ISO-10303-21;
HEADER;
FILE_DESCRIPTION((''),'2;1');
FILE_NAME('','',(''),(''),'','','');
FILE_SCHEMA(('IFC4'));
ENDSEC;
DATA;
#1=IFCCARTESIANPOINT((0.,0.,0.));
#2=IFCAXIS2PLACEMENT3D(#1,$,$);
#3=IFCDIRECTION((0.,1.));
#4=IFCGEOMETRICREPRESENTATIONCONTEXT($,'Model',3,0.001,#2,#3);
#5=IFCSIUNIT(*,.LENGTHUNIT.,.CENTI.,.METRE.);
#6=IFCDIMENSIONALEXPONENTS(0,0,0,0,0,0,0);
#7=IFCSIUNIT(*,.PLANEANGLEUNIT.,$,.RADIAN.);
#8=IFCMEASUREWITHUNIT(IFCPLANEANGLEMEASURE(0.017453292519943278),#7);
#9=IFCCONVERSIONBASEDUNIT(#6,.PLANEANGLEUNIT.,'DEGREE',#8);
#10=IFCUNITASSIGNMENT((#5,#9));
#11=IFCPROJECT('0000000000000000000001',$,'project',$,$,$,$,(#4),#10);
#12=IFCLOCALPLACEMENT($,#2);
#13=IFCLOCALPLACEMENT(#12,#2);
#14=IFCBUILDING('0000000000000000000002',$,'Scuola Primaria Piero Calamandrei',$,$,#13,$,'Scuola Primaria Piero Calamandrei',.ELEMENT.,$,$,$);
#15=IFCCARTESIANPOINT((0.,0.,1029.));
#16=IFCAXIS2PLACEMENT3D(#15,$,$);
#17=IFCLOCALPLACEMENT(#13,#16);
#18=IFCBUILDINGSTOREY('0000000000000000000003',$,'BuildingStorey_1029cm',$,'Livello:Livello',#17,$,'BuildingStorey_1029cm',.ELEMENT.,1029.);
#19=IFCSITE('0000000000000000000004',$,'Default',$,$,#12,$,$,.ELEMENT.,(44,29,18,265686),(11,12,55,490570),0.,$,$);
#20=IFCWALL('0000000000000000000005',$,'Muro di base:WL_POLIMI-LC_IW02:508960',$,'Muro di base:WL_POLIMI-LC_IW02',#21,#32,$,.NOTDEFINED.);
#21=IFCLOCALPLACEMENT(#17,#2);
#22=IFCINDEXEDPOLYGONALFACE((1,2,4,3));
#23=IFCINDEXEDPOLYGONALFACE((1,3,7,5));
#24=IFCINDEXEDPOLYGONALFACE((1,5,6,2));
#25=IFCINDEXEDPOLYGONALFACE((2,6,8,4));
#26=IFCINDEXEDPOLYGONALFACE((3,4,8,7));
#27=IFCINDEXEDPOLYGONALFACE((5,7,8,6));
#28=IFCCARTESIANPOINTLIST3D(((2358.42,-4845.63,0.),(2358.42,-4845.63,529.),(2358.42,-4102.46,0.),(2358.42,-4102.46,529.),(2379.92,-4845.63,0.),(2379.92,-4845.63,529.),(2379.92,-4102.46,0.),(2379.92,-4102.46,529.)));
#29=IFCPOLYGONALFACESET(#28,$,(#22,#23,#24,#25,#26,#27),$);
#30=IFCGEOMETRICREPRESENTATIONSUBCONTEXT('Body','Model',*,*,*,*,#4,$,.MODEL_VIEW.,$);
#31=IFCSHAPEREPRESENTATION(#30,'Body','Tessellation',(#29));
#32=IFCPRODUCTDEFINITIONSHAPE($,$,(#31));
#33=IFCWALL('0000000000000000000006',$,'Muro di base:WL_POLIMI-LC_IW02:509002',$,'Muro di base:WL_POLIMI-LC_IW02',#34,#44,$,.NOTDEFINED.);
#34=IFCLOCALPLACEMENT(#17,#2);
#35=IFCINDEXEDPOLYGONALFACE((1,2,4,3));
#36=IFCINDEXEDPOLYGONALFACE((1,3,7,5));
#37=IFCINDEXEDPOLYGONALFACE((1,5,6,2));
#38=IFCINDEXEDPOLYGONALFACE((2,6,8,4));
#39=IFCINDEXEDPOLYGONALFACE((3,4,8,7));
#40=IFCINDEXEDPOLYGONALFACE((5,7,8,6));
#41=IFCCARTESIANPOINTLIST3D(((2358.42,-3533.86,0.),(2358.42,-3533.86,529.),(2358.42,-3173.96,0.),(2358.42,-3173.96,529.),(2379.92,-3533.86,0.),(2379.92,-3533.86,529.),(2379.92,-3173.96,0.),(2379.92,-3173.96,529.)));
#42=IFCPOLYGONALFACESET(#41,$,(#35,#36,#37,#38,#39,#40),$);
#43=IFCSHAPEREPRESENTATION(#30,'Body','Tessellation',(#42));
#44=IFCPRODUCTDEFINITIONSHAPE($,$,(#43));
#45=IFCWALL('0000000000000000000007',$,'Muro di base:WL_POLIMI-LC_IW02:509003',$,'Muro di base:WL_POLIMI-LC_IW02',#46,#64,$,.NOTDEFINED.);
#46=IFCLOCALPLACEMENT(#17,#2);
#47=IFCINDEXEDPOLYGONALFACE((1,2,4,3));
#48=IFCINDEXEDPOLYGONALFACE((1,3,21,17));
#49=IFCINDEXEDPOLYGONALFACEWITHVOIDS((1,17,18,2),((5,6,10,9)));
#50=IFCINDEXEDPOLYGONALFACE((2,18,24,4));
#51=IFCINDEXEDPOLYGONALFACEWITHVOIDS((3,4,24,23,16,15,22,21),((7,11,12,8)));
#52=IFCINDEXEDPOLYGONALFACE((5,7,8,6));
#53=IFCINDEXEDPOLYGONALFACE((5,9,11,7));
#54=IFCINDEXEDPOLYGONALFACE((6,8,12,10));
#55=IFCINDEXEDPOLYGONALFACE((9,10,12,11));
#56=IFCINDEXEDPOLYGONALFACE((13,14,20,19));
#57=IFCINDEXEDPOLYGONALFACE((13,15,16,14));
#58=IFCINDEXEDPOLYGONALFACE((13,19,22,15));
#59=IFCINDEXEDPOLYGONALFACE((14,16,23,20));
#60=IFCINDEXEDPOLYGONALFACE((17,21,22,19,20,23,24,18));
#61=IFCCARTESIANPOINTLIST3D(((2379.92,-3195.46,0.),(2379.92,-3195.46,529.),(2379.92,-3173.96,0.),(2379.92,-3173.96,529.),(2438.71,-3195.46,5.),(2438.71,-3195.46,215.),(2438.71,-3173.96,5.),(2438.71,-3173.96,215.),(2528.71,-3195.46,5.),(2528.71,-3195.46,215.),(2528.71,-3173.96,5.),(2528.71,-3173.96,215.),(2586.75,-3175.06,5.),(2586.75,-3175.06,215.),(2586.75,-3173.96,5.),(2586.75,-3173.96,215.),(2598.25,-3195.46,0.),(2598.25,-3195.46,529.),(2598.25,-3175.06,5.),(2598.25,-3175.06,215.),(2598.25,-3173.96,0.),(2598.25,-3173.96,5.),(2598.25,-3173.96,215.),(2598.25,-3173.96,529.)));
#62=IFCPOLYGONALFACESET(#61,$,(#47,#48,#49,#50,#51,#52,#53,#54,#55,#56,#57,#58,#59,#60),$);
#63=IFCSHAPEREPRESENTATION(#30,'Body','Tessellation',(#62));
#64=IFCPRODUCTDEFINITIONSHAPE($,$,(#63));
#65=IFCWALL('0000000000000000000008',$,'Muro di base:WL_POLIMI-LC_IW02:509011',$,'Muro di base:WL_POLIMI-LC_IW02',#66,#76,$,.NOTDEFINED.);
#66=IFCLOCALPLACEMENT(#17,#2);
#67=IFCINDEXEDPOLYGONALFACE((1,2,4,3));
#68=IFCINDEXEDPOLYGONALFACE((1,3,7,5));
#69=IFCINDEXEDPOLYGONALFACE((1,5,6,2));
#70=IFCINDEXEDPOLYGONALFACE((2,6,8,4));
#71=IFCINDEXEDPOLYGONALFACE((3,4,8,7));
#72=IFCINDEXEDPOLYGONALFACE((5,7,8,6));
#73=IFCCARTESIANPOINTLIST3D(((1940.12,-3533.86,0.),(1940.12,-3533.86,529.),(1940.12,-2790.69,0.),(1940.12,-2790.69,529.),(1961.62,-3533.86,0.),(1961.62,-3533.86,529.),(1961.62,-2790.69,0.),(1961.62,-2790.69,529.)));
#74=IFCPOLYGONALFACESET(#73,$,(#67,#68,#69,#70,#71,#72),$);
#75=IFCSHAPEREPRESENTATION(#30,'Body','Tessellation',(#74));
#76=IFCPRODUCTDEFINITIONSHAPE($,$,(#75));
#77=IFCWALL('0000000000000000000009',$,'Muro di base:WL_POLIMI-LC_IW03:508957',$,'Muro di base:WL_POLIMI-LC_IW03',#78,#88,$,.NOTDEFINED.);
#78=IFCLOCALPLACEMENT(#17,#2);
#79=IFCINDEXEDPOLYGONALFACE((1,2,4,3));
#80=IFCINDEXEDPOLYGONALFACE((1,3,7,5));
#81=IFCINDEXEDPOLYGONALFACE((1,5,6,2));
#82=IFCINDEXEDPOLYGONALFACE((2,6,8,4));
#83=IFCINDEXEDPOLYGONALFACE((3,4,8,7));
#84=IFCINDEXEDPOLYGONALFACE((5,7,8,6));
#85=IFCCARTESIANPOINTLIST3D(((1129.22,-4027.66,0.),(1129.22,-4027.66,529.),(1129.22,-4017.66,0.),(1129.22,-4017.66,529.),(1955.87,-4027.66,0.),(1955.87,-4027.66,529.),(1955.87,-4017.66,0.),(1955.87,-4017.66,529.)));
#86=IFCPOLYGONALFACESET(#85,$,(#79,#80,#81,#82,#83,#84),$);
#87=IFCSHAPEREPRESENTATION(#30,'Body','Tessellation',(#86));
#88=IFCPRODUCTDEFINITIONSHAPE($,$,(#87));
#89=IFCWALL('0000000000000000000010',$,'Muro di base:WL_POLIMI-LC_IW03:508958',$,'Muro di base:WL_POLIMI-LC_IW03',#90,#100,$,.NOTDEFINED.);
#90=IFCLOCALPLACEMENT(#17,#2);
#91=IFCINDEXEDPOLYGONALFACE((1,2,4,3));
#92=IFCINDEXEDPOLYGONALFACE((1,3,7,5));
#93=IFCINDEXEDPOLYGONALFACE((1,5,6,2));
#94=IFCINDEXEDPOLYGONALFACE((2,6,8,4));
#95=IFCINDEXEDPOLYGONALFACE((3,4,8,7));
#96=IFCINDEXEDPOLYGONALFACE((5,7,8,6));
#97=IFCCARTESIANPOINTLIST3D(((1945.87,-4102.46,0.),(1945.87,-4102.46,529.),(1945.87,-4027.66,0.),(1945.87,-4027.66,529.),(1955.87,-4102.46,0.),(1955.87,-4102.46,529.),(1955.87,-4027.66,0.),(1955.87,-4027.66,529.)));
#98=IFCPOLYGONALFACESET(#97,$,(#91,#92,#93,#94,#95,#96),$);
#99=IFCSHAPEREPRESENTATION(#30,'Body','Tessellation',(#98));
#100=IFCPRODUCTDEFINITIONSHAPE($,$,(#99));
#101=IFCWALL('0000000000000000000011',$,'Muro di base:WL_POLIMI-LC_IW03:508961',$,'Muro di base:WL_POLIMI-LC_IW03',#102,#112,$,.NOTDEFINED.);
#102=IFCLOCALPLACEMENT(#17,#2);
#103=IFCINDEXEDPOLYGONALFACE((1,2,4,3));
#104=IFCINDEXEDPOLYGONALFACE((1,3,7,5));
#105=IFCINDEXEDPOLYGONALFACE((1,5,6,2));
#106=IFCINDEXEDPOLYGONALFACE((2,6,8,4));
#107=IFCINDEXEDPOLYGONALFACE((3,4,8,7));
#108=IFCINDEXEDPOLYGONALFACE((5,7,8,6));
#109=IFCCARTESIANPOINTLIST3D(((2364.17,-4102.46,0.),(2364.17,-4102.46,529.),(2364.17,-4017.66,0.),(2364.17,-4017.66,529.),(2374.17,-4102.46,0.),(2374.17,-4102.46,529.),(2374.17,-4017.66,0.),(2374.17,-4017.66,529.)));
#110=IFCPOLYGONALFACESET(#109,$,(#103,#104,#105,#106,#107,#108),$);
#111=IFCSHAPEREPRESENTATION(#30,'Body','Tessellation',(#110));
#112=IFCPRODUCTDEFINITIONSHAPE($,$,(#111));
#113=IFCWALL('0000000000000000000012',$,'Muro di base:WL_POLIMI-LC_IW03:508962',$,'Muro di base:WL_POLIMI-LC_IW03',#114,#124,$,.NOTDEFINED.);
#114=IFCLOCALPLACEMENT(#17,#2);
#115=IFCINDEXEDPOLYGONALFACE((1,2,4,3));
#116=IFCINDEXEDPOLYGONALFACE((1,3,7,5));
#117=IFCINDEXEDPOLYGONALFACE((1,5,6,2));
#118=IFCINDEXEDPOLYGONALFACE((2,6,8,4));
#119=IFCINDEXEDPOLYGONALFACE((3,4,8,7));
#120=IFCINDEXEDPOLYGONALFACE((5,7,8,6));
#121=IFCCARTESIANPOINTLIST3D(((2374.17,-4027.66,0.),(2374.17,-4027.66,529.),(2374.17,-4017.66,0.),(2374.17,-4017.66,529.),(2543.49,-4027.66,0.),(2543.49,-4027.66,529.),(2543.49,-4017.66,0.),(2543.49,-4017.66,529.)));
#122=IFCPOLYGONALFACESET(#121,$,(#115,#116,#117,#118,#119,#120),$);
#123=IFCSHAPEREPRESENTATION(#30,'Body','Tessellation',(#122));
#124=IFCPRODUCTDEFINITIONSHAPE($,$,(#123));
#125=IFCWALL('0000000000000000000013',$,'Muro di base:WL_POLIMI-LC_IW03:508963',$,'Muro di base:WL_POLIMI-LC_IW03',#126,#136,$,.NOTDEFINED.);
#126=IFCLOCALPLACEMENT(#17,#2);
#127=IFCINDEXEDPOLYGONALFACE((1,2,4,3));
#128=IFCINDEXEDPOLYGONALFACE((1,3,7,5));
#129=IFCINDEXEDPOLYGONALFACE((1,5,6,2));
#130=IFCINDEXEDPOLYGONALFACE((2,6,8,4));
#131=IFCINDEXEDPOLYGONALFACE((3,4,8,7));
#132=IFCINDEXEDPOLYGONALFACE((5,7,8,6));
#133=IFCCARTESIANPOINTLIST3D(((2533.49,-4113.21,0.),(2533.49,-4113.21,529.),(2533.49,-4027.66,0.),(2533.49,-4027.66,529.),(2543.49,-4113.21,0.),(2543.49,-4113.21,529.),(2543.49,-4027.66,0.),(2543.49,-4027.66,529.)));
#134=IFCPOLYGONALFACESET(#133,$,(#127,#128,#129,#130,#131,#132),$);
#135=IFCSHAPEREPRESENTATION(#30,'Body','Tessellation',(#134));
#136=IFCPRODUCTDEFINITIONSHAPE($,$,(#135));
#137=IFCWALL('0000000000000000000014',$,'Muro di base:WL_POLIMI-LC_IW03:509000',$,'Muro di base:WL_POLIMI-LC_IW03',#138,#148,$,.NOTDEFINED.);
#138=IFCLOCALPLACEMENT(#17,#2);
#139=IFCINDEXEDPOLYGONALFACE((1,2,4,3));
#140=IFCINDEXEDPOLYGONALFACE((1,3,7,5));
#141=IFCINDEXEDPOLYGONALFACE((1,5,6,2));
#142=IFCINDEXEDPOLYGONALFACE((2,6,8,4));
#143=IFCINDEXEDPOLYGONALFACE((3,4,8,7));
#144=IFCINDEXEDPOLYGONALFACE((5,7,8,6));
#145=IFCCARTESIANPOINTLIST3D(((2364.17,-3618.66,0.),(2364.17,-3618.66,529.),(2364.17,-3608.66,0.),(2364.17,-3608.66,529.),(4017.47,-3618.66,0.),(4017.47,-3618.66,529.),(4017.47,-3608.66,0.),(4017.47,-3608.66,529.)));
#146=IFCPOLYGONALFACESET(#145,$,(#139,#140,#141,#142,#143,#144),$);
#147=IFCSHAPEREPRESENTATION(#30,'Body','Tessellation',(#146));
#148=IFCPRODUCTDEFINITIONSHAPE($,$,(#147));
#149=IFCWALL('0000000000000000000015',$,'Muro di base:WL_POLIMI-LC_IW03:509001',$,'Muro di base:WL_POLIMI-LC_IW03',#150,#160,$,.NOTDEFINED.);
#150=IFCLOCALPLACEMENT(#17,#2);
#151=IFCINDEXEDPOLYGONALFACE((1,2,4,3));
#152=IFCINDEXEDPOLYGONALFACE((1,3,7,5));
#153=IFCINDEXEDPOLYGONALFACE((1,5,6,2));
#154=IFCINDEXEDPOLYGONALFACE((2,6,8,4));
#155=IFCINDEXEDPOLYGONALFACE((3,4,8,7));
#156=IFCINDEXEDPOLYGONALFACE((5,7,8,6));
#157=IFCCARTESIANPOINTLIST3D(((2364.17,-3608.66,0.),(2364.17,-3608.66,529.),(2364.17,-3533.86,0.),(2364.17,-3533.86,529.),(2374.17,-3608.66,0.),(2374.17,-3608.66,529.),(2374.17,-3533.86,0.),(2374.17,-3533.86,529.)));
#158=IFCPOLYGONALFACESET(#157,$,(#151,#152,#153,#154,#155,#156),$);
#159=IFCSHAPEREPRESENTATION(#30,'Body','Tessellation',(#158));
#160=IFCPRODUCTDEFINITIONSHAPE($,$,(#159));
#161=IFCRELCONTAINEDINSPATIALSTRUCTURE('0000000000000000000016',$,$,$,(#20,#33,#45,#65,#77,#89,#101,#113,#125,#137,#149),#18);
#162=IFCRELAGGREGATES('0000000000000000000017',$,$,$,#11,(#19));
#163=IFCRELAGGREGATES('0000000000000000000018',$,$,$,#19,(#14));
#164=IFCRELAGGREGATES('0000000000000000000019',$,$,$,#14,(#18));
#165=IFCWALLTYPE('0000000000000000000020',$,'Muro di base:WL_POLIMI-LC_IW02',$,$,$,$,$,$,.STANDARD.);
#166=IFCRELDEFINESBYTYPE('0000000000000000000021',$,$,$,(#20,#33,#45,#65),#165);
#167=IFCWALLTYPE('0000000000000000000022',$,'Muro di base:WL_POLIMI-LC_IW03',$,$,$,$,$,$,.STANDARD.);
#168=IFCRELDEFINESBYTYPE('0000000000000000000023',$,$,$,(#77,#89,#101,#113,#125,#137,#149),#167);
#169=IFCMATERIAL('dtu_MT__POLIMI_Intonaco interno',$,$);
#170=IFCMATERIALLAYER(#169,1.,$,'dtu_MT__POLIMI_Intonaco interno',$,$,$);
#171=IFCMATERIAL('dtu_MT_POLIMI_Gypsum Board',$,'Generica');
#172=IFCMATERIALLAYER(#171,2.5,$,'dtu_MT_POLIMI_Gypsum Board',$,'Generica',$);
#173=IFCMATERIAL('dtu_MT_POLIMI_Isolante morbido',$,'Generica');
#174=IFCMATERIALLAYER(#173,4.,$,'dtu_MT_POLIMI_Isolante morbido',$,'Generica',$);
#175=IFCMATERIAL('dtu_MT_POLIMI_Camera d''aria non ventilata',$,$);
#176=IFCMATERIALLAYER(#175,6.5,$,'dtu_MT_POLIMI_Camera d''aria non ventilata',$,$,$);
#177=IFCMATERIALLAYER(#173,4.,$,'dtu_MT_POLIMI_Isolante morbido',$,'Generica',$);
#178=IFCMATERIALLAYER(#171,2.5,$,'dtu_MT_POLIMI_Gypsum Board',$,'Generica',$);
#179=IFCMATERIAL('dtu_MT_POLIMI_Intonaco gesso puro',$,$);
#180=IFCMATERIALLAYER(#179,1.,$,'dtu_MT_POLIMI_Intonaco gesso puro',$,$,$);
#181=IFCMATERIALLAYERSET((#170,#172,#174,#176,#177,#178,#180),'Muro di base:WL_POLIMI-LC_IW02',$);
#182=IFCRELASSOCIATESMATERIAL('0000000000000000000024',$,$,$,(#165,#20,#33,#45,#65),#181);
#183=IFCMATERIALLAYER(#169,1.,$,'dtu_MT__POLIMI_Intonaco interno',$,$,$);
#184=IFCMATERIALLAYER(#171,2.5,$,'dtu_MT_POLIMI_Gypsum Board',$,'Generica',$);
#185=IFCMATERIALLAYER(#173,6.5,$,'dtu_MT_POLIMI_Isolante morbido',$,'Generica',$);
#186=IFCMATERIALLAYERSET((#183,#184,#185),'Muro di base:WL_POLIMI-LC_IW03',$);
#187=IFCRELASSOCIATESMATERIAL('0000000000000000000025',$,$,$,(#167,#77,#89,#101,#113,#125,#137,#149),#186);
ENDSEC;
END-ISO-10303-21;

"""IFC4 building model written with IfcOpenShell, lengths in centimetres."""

from ifc_helpers import new_model, entity, si_unit, converted_unit, direction, frame, frame_2d, origin, place, context, subcontext, project, spatial, rectangle, extrude, material, layer, layer_set, layer_usage, type_object, element, save


model = new_model("IFC4")

# Units and contexts
model_context = context("Model", 3, precision=0.001, world=origin(), true_north=direction((0.0, 1.0)))
body_context = subcontext(model_context, "Body", "Model", "MODEL_VIEW")
ifc_project = project(units=[si_unit("LENGTHUNIT", "METRE", prefix="CENTI"), converted_unit("PLANEANGLEUNIT", "DEGREE", entity("IfcPlaneAngleMeasure", 0.017453292519943278), si_unit("PLANEANGLEUNIT", "RADIAN"), dimensions=[0, 0, 0, 0, 0, 0, 0])], contexts=[model_context])

# Site, building, storey
site_placement = place(None, origin())
site = spatial("IfcSite", under=ifc_project, at=site_placement, Name="Default", CompositionType="ELEMENT", RefLatitude=(44, 29, 18, 265686), RefLongitude=(11, 12, 55, 490570), RefElevation=0.0)
building_placement = place(site_placement, origin())
building = spatial("IfcBuilding", under=site, at=building_placement, Name="Scuola Primaria Piero Calamandrei", LongName="Scuola Primaria Piero Calamandrei", CompositionType="ELEMENT")
storey_placement = place(building_placement, frame((0.0, 0.0, 1029.0)))
storey = spatial("IfcBuildingStorey", under=building, at=storey_placement, Name="BuildingStorey_1029cm", ObjectType="Livello:Livello", LongName="BuildingStorey_1029cm", CompositionType="ELEMENT", Elevation=1029.0)

# Walls
ifc_material_1 = material(Name="dtu_MT_POLIMI_Isolante morbido", Category="Generica")
ifc_material_2 = material(Name="dtu_MT_POLIMI_Gypsum Board", Category="Generica")
ifc_material_3 = material(Name="dtu_MT__POLIMI_Intonaco interno")
ifc_layer_1 = layer(ifc_material_3, 1.0, Name="dtu_MT__POLIMI_Intonaco interno")
ifc_layer_2 = layer(ifc_material_2, 2.5, Name="dtu_MT_POLIMI_Gypsum Board", Category="Generica")
ifc_layer_3 = layer(ifc_material_1, 4.0, Name="dtu_MT_POLIMI_Isolante morbido", Category="Generica")
ifc_material_4 = material(Name="dtu_MT_POLIMI_Camera d'aria non ventilata")
ifc_layer_4 = layer(ifc_material_4, 6.5, Name="dtu_MT_POLIMI_Camera d'aria non ventilata")
ifc_layer_5 = layer(ifc_material_1, 4.0, Name="dtu_MT_POLIMI_Isolante morbido", Category="Generica")
ifc_layer_6 = layer(ifc_material_2, 2.5, Name="dtu_MT_POLIMI_Gypsum Board", Category="Generica")
ifc_material_5 = material(Name="dtu_MT_POLIMI_Intonaco gesso puro")
ifc_layer_7 = layer(ifc_material_5, 1.0, Name="dtu_MT_POLIMI_Intonaco gesso puro")
ifc_layer_set_1 = layer_set([ifc_layer_1, ifc_layer_2, ifc_layer_3, ifc_layer_4, ifc_layer_5, ifc_layer_6, ifc_layer_7], Name="Muro di base:WL_POLIMI-LC_IW02")
wall_type_1 = type_object("IfcWallType", Name="Muro di base:WL_POLIMI-LC_IW02", PredefinedType="STANDARD", material=ifc_layer_set_1)
ifc_layer_usage_1 = layer_usage(ifc_layer_set_1, "AXIS2", "NEGATIVE", 10.75)
wall_1_placement = place(storey_placement, frame((2369.17, -4102.46, 0.0), z_axis=(0.0, 0.0, 1.0), x_axis=(0.0, -1.0, 0.0)))
element("IfcWall", 1, at=wall_1_placement, inside=storey, type_object=wall_type_1, material=ifc_layer_usage_1, Name="Muro di base:WL_POLIMI-LC_IW02:508960", ObjectType="Muro di base:WL_POLIMI-LC_IW02", PredefinedType="NOTDEFINED", context=body_context, shape_type="SweptSolid", body=[
    extrude(rectangle(XDim=743.17, YDim=21.5, at=frame_2d((371.58, 0.0), x_axis=(-1.0, 0.0))), origin(), (0.0, 0.0, 1.0), 529.0),
])
ifc_layer_usage_2 = layer_usage(ifc_layer_set_1, "AXIS2", "NEGATIVE", 10.75)
wall_2_placement = place(storey_placement, frame((2369.17, -3173.96, 0.0), z_axis=(0.0, 0.0, 1.0), x_axis=(0.0, -1.0, 0.0)))
element("IfcWall", 2, at=wall_2_placement, inside=storey, type_object=wall_type_1, material=ifc_layer_usage_2, Name="Muro di base:WL_POLIMI-LC_IW02:509002", ObjectType="Muro di base:WL_POLIMI-LC_IW02", PredefinedType="NOTDEFINED", context=body_context, shape_type="SweptSolid", body=[
    extrude(rectangle(XDim=359.89, YDim=21.5, at=frame_2d((179.95, 0.0), x_axis=(-1.0, 0.0))), origin(), (0.0, 0.0, 1.0), 529.0),
])

# Wall, openings
ifc_layer_usage_3 = layer_usage(ifc_layer_set_1, "AXIS2", "NEGATIVE", 10.75)
wall_3_placement = place(storey_placement, frame((2598.25, -3184.71, 0.0), z_axis=(0.0, 0.0, 1.0), x_axis=(-1.0, 0.0, 0.0)))
wall_3 = element("IfcWall", 3, at=wall_3_placement, inside=storey, type_object=wall_type_1, material=ifc_layer_usage_3, Name="Muro di base:WL_POLIMI-LC_IW02:509003", ObjectType="Muro di base:WL_POLIMI-LC_IW02", PredefinedType="NOTDEFINED", context=body_context, shape_type="SweptSolid", body=[
    extrude(rectangle(XDim=218.32, YDim=21.5, at=frame_2d((109.16, 0.0), x_axis=(-1.0, 0.0))), origin(), (0.0, 0.0, 1.0), 529.0),
])
opening_1_placement = place(wall_3_placement, frame((2598.25, -3184.71, 5.0)))
element("IfcOpeningElement", 4, at=opening_1_placement, cuts=wall_3, PredefinedType="OPENING", context=body_context, shape_type="SweptSolid", body=[
    extrude(rectangle(XDim=210.0, YDim=23.0, at=frame_2d((0.0, 0.0), x_axis=(0.0, 1.0))), frame((-2598.25, 3095.06, 105.0), z_axis=(0.0, 1.0, 0.0), x_axis=(-1.0, 0.0, 0.0)), (0.0, 0.0, 1.0), 80.0),
])
opening_2_placement = place(wall_3_placement, frame((159.54, 10.75, 5.0)))
element("IfcOpeningElement", 5, at=opening_2_placement, cuts=wall_3, PredefinedType="OPENING", context=body_context, shape_type="SweptSolid", body=[
    extrude(rectangle(XDim=210.0, YDim=90.0, at=frame_2d((105.0, 45.0), x_axis=(1.0, 0.0))), frame((0.0, 0.0, 0.0), z_axis=(0.0, -1.0, 0.0), x_axis=(0.0, 0.0, 1.0)), (0.0, 0.0, 1.0), 21.5),
])

# Walls
ifc_layer_usage_4 = layer_usage(ifc_layer_set_1, "AXIS2", "NEGATIVE", 10.75)
wall_4_placement = place(storey_placement, frame((1950.87, -3533.86, 0.0), z_axis=(0.0, 0.0, 1.0), x_axis=(0.0, 1.0, 0.0)))
element("IfcWall", 6, at=wall_4_placement, inside=storey, type_object=wall_type_1, material=ifc_layer_usage_4, Name="Muro di base:WL_POLIMI-LC_IW02:509011", ObjectType="Muro di base:WL_POLIMI-LC_IW02", PredefinedType="NOTDEFINED", context=body_context, shape_type="SweptSolid", body=[
    extrude(rectangle(XDim=743.17, YDim=21.5, at=frame_2d((371.58, 0.0), x_axis=(-1.0, 0.0))), origin(), (0.0, 0.0, 1.0), 529.0),
])
ifc_layer_8 = layer(ifc_material_3, 1.0, Name="dtu_MT__POLIMI_Intonaco interno")
ifc_layer_9 = layer(ifc_material_2, 2.5, Name="dtu_MT_POLIMI_Gypsum Board", Category="Generica")
ifc_layer_10 = layer(ifc_material_1, 6.5, Name="dtu_MT_POLIMI_Isolante morbido", Category="Generica")
ifc_layer_set_2 = layer_set([ifc_layer_8, ifc_layer_9, ifc_layer_10], Name="Muro di base:WL_POLIMI-LC_IW03")
ifc_layer_usage_5 = layer_usage(ifc_layer_set_2, "AXIS2", "NEGATIVE", 5.0)
wall_type_2 = type_object("IfcWallType", Name="Muro di base:WL_POLIMI-LC_IW03", PredefinedType="STANDARD", material=ifc_layer_set_2)
wall_5_placement = place(storey_placement, frame((1955.87, -4022.66, 0.0), z_axis=(0.0, 0.0, 1.0), x_axis=(-1.0, 0.0, 0.0)))
element("IfcWall", 7, at=wall_5_placement, inside=storey, type_object=wall_type_2, material=ifc_layer_usage_5, Name="Muro di base:WL_POLIMI-LC_IW03:508957", ObjectType="Muro di base:WL_POLIMI-LC_IW03", PredefinedType="NOTDEFINED", context=body_context, shape_type="SweptSolid", body=[
    extrude(rectangle(XDim=826.65, YDim=10.0, at=frame_2d((413.32, 0.0), x_axis=(-1.0, 0.0))), origin(), (0.0, 0.0, 1.0), 529.0),
])
ifc_layer_usage_6 = layer_usage(ifc_layer_set_2, "AXIS2", "NEGATIVE", 5.0)
wall_6_placement = place(storey_placement, frame((1950.87, -4102.46, 0.0), z_axis=(0.0, 0.0, 1.0), x_axis=(0.0, 1.0, 0.0)))
element("IfcWall", 8, at=wall_6_placement, inside=storey, type_object=wall_type_2, material=ifc_layer_usage_6, Name="Muro di base:WL_POLIMI-LC_IW03:508958", ObjectType="Muro di base:WL_POLIMI-LC_IW03", PredefinedType="NOTDEFINED", context=body_context, shape_type="SweptSolid", body=[
    extrude(rectangle(XDim=74.8, YDim=10.0, at=frame_2d((37.4, 0.0), x_axis=(-1.0, 0.0))), origin(), (0.0, 0.0, 1.0), 529.0),
])
ifc_layer_usage_7 = layer_usage(ifc_layer_set_2, "AXIS2", "NEGATIVE", 5.0)
wall_7_placement = place(storey_placement, frame((2369.17, -4017.66, 0.0), z_axis=(0.0, 0.0, 1.0), x_axis=(0.0, -1.0, 0.0)))
element("IfcWall", 9, at=wall_7_placement, inside=storey, type_object=wall_type_2, material=ifc_layer_usage_7, Name="Muro di base:WL_POLIMI-LC_IW03:508961", ObjectType="Muro di base:WL_POLIMI-LC_IW03", PredefinedType="NOTDEFINED", context=body_context, shape_type="SweptSolid", body=[
    extrude(rectangle(XDim=84.8, YDim=10.0, at=frame_2d((42.4, 0.0), x_axis=(-1.0, 0.0))), origin(), (0.0, 0.0, 1.0), 529.0),
])
ifc_layer_usage_8 = layer_usage(ifc_layer_set_2, "AXIS2", "NEGATIVE", 5.0)
wall_8_placement = place(storey_placement, frame((2543.49, -4022.66, 0.0), z_axis=(0.0, 0.0, 1.0), x_axis=(-1.0, 0.0, 0.0)))
element("IfcWall", 10, at=wall_8_placement, inside=storey, type_object=wall_type_2, material=ifc_layer_usage_8, Name="Muro di base:WL_POLIMI-LC_IW03:508962", ObjectType="Muro di base:WL_POLIMI-LC_IW03", PredefinedType="NOTDEFINED", context=body_context, shape_type="SweptSolid", body=[
    extrude(rectangle(XDim=169.31, YDim=10.0, at=frame_2d((84.66, 0.0), x_axis=(-1.0, 0.0))), origin(), (0.0, 0.0, 1.0), 529.0),
])
ifc_layer_usage_9 = layer_usage(ifc_layer_set_2, "AXIS2", "NEGATIVE", 5.0)
wall_9_placement = place(storey_placement, frame((2538.49, -4113.21, 0.0), z_axis=(0.0, 0.0, 1.0), x_axis=(0.0, 1.0, 0.0)))
element("IfcWall", 11, at=wall_9_placement, inside=storey, type_object=wall_type_2, material=ifc_layer_usage_9, Name="Muro di base:WL_POLIMI-LC_IW03:508963", ObjectType="Muro di base:WL_POLIMI-LC_IW03", PredefinedType="NOTDEFINED", context=body_context, shape_type="SweptSolid", body=[
    extrude(rectangle(XDim=85.55, YDim=10.0, at=frame_2d((42.78, 0.0), x_axis=(-1.0, 0.0))), origin(), (0.0, 0.0, 1.0), 529.0),
])
ifc_layer_usage_10 = layer_usage(ifc_layer_set_2, "AXIS2", "NEGATIVE", 5.0)
wall_10_placement = place(storey_placement, frame((2364.17, -3613.66, 0.0)))
element("IfcWall", 12, at=wall_10_placement, inside=storey, type_object=wall_type_2, material=ifc_layer_usage_10, Name="Muro di base:WL_POLIMI-LC_IW03:509000", ObjectType="Muro di base:WL_POLIMI-LC_IW03", PredefinedType="NOTDEFINED", context=body_context, shape_type="SweptSolid", body=[
    extrude(rectangle(XDim=1653.3, YDim=10.0, at=frame_2d((826.65, 0.0), x_axis=(-1.0, 0.0))), origin(), (0.0, 0.0, 1.0), 529.0),
])
ifc_layer_usage_11 = layer_usage(ifc_layer_set_2, "AXIS2", "NEGATIVE", 5.0)
wall_11_placement = place(storey_placement, frame((2369.17, -3533.86, 0.0), z_axis=(0.0, 0.0, 1.0), x_axis=(0.0, -1.0, 0.0)))
element("IfcWall", 13, at=wall_11_placement, inside=storey, type_object=wall_type_2, material=ifc_layer_usage_11, Name="Muro di base:WL_POLIMI-LC_IW03:509001", ObjectType="Muro di base:WL_POLIMI-LC_IW03", PredefinedType="NOTDEFINED", context=body_context, shape_type="SweptSolid", body=[
    extrude(rectangle(XDim=74.8, YDim=10.0, at=frame_2d((37.4, 0.0), x_axis=(-1.0, 0.0))), origin(), (0.0, 0.0, 1.0), 529.0),
])

save(model, "model.ifc")
